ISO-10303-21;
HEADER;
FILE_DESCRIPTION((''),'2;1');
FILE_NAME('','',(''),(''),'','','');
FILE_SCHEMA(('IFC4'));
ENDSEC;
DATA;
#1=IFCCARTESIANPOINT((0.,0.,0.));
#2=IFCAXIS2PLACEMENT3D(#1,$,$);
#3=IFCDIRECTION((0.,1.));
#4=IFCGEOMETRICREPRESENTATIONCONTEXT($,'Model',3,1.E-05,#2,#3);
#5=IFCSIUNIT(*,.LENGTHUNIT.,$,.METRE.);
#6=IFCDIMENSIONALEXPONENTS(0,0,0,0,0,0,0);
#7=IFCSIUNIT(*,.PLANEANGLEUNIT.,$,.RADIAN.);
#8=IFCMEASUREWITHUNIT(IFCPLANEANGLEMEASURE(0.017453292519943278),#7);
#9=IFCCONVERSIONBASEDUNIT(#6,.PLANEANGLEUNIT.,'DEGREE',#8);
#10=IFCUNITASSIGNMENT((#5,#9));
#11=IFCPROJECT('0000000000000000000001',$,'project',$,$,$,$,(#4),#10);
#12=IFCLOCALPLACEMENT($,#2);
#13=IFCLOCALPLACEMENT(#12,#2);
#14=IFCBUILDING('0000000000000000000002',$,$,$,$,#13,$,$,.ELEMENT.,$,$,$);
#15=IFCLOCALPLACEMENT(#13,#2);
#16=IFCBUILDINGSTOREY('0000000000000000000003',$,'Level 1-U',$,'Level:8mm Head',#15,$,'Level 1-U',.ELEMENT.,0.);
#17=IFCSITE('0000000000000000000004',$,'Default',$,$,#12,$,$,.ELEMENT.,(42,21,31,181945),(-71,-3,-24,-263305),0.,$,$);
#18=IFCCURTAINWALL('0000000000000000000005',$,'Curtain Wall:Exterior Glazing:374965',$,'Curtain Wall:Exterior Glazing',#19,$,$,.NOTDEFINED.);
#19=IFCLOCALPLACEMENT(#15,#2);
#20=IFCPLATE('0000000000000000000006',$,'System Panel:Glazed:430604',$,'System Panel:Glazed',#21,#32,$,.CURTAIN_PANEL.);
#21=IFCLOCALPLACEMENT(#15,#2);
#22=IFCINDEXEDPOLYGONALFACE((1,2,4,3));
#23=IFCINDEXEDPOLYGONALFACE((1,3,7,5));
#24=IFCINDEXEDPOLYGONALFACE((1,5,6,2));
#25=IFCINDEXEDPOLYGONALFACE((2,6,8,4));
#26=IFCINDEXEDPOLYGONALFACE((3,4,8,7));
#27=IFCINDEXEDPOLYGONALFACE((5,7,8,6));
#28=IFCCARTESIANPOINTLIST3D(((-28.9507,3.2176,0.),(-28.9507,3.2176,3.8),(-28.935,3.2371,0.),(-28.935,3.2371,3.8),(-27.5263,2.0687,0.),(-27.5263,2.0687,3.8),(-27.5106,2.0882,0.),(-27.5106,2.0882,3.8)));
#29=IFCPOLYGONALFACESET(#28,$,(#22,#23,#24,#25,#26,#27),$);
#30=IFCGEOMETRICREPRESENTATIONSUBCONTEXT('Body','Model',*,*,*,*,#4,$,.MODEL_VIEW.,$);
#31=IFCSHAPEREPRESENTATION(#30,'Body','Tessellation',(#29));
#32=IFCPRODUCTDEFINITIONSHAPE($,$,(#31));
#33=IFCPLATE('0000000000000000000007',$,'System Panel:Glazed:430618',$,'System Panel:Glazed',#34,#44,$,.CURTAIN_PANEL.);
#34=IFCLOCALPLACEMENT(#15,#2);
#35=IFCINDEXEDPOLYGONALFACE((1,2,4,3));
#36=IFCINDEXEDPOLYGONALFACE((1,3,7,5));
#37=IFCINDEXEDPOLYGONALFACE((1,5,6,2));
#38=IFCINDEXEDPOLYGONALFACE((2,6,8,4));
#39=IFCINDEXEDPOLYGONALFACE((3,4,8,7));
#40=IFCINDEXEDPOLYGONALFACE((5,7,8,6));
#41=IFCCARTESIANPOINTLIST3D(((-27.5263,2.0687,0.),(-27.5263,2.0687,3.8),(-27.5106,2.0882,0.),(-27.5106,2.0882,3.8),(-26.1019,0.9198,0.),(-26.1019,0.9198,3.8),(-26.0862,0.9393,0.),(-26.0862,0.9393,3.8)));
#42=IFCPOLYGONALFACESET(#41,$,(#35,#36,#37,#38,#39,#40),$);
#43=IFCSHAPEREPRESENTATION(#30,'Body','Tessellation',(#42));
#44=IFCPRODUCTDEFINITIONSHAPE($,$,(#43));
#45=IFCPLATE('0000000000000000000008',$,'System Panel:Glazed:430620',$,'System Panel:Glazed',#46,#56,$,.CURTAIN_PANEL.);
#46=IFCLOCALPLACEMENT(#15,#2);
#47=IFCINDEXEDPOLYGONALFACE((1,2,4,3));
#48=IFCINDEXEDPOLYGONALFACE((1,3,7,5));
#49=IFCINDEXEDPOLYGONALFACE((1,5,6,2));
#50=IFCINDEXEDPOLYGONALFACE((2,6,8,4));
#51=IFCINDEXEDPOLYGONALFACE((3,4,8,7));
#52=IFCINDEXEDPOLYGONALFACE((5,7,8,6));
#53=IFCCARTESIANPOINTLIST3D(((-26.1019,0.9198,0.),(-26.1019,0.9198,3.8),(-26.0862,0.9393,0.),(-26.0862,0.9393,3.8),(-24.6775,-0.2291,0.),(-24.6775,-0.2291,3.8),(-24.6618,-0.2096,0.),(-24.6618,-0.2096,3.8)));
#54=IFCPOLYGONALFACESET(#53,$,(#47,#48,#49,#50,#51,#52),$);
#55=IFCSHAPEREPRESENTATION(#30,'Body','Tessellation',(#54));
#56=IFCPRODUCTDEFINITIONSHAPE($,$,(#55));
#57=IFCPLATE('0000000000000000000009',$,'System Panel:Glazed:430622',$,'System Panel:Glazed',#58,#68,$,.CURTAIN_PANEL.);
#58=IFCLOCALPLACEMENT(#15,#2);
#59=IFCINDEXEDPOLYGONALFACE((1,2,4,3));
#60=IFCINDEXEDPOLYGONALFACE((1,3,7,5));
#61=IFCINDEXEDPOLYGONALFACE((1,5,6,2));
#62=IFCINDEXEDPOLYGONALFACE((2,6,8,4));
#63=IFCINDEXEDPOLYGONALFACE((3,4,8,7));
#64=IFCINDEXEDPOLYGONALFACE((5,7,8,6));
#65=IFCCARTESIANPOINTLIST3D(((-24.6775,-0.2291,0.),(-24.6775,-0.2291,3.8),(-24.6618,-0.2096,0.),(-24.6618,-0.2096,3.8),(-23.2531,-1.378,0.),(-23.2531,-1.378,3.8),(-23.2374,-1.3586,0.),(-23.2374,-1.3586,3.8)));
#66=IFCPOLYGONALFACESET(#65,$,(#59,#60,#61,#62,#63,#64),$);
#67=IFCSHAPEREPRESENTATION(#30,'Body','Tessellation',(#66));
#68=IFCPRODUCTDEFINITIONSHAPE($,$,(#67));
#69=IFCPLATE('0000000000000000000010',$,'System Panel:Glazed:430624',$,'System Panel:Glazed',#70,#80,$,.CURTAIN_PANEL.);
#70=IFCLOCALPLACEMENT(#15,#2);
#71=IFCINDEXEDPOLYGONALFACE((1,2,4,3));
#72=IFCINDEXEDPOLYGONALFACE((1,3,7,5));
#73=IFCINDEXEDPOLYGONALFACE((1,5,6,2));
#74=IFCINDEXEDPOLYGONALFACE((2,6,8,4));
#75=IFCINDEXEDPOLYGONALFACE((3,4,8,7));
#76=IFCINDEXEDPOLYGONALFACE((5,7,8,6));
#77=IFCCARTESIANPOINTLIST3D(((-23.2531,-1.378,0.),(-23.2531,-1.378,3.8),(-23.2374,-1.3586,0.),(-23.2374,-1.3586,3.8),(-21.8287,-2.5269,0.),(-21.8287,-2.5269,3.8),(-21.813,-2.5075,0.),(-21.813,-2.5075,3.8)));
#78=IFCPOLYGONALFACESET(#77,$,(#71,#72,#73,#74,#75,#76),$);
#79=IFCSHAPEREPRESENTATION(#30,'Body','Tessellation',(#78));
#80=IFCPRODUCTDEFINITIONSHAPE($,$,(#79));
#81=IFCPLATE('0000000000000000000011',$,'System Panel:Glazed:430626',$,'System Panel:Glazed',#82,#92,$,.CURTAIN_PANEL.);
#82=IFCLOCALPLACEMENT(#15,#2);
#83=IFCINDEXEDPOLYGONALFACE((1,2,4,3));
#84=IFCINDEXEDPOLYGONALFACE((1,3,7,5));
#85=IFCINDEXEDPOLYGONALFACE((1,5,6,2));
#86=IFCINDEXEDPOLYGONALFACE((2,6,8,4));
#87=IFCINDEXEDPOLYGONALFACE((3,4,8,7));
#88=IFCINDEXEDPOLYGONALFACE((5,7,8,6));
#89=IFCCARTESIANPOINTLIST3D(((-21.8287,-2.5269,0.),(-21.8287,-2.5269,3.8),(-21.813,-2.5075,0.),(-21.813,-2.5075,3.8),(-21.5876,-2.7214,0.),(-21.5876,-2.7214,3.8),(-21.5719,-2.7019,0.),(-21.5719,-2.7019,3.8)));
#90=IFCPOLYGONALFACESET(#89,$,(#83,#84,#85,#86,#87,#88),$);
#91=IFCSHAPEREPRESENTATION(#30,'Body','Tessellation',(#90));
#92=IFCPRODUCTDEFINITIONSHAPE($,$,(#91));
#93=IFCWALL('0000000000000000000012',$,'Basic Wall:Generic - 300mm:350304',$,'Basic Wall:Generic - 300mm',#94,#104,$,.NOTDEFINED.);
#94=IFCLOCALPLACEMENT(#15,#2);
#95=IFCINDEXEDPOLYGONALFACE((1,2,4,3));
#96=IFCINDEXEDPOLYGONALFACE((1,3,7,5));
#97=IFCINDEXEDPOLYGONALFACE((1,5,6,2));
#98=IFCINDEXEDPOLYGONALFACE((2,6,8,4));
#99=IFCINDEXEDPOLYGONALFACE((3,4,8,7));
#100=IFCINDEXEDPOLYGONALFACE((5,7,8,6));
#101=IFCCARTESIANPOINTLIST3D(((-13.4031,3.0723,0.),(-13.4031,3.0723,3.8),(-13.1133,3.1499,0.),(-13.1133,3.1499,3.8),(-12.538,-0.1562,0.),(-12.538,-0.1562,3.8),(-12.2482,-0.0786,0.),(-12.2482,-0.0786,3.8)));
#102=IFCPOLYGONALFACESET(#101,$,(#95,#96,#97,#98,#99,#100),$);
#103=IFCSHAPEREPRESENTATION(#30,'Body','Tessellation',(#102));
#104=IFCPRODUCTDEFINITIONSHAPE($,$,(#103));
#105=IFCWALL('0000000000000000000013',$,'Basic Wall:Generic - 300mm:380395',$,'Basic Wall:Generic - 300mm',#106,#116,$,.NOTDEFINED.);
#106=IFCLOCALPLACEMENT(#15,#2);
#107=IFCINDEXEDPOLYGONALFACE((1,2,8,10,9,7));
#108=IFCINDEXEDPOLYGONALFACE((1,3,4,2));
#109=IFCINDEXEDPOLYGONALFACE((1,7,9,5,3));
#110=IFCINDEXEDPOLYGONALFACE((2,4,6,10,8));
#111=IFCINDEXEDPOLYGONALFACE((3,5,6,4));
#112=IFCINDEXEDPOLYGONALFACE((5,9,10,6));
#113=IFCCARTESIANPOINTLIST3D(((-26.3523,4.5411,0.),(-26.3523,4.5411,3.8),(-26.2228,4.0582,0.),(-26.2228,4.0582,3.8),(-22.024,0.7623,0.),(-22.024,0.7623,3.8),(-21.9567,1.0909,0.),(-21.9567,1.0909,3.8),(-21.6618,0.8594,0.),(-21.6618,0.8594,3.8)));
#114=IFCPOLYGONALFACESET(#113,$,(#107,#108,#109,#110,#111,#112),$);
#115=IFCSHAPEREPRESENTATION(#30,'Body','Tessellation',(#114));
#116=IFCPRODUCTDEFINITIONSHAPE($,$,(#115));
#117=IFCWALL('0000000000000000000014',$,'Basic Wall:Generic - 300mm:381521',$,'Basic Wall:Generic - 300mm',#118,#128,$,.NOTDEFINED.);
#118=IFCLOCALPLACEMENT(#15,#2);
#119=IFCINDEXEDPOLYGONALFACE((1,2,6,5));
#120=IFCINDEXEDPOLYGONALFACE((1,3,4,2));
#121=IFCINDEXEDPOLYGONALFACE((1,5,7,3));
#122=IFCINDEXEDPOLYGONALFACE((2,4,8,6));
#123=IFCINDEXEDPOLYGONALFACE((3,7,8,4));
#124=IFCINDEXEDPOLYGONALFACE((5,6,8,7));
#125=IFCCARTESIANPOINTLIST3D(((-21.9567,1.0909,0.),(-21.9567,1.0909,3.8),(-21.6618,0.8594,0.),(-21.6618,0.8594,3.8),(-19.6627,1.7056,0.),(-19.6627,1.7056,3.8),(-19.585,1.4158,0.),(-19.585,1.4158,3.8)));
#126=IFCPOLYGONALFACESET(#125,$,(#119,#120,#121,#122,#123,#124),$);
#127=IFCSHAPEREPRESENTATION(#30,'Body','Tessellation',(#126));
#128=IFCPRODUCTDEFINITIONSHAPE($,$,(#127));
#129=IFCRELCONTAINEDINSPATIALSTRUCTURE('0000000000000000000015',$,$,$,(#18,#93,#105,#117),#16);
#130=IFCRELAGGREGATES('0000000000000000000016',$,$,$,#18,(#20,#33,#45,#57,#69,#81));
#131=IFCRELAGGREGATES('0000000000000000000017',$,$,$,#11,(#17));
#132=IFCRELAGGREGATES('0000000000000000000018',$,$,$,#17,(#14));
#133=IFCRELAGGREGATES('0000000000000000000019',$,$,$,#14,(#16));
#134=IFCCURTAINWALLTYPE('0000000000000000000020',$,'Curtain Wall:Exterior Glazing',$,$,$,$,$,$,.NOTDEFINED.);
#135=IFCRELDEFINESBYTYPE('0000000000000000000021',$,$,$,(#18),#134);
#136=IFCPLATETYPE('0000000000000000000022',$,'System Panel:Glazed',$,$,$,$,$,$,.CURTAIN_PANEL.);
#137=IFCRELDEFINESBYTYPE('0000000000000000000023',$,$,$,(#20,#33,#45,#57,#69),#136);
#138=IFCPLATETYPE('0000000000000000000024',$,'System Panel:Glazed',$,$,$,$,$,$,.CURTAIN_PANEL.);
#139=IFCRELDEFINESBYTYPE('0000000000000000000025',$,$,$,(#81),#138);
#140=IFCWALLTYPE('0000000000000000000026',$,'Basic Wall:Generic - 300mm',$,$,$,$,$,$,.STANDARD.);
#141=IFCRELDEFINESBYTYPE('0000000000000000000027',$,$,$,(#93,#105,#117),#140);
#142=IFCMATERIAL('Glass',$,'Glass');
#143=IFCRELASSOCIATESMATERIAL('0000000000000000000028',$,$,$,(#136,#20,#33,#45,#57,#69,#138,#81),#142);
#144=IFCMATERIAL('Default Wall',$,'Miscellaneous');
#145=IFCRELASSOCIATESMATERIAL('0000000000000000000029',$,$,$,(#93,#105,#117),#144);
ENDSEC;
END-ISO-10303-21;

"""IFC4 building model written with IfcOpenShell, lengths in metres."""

from ifc_helpers import new_model, entity, si_unit, converted_unit, direction, frame, origin, place, context, subcontext, project, spatial, indexed_curve, outline, extrude, source, transform, mapped, material, type_object, type_shapes, element, aggregate, save


model = new_model("IFC4")

# Units and contexts
model_context = context("Model", 3, precision=1e-05, world=origin(), true_north=direction((0.0, 1.0)))
body_context = subcontext(model_context, "Body", "Model", "MODEL_VIEW")
ifc_project = project(units=[si_unit("LENGTHUNIT", "METRE"), converted_unit("PLANEANGLEUNIT", "DEGREE", entity("IfcPlaneAngleMeasure", 0.017453292519943278), si_unit("PLANEANGLEUNIT", "RADIAN"), dimensions=[0, 0, 0, 0, 0, 0, 0])], contexts=[model_context])

# Site, building, storey
site_placement = place(None, origin())
site = spatial("IfcSite", under=ifc_project, at=site_placement, Name="Default", CompositionType="ELEMENT", RefLatitude=(42, 21, 31, 181945), RefLongitude=(-71, -3, -24, -263305), RefElevation=0.0)
building_placement = place(site_placement, origin())
building = spatial("IfcBuilding", under=site, at=building_placement, CompositionType="ELEMENT")
storey_placement = place(building_placement, origin())
storey = spatial("IfcBuildingStorey", under=building, at=storey_placement, Name="Level 1-U", ObjectType="Level:8mm Head", LongName="Level 1-U", CompositionType="ELEMENT", Elevation=0.0)

# Curtain wall, plates
curtain_wall_type = type_object("IfcCurtainWallType", Name="Curtain Wall:Exterior Glazing", PredefinedType="NOTDEFINED")
curtain_wall_placement = place(storey_placement, origin())
curtain_wall = element("IfcCurtainWall", 1, at=curtain_wall_placement, inside=storey, type_object=curtain_wall_type, Name="Curtain Wall:Exterior Glazing:374965", ObjectType="Curtain Wall:Exterior Glazing", PredefinedType="NOTDEFINED")
ifc_material_1 = material(Name="Glass", Category="Glass")
plate_type_1 = type_object("IfcPlateType", Name="System Panel:Glazed", PredefinedType="CURTAIN_PANEL", material=ifc_material_1)
shared_shape_1 = source(origin(), body_context, "Body", "SweptSolid", [
    extrude(outline(indexed_curve([(-0.0125, -0.915), (0.0125, -0.915), (0.0125, 0.915), (-0.0125, 0.915), (-0.0125, -0.915)], self_intersect=False)), frame((0.0, 0.037, 0.0), z_axis=(0.0, 0.0, 1.0), x_axis=(0.0, 1.0, 0.0)), (0.0, 0.0, 1.0), 3.8),
])
type_shapes(plate_type_1, [shared_shape_1])
plate_1_placement = place(curtain_wall_placement, frame((-28.2539, 2.6241, 0.0), z_axis=(0.0, 0.0, 1.0), x_axis=(0.778359, -0.62782, 0.0)))
plate_1 = element("IfcPlate", 2, at=plate_1_placement, type_object=plate_type_1, material=ifc_material_1, Name="System Panel:Glazed:430604", ObjectType="System Panel:Glazed", PredefinedType="CURTAIN_PANEL", context=body_context, shape_type="MappedRepresentation", body=[
    mapped(shared_shape_1, transform((0.0, 0.0, 0.0), scale=1.0)),
])
plate_2_placement = place(curtain_wall_placement, frame((-26.8295, 1.4752, 0.0), z_axis=(0.0, 0.0, 1.0), x_axis=(0.778359, -0.62782, 0.0)))
plate_2 = element("IfcPlate", 3, at=plate_2_placement, type_object=plate_type_1, material=ifc_material_1, Name="System Panel:Glazed:430618", ObjectType="System Panel:Glazed", PredefinedType="CURTAIN_PANEL", context=body_context, shape_type="MappedRepresentation", body=[
    mapped(shared_shape_1, transform((0.0, 0.0, 0.0), scale=1.0)),
])
plate_3_placement = place(curtain_wall_placement, frame((-25.4051, 0.3263, 0.0), z_axis=(0.0, 0.0, 1.0), x_axis=(0.778359, -0.62782, 0.0)))
plate_3 = element("IfcPlate", 4, at=plate_3_placement, type_object=plate_type_1, material=ifc_material_1, Name="System Panel:Glazed:430620", ObjectType="System Panel:Glazed", PredefinedType="CURTAIN_PANEL", context=body_context, shape_type="MappedRepresentation", body=[
    mapped(shared_shape_1, transform((0.0, 0.0, 0.0), scale=1.0)),
])
plate_4_placement = place(curtain_wall_placement, frame((-23.9807, -0.8226, 0.0), z_axis=(0.0, 0.0, 1.0), x_axis=(0.778359, -0.62782, 0.0)))
plate_4 = element("IfcPlate", 5, at=plate_4_placement, type_object=plate_type_1, material=ifc_material_1, Name="System Panel:Glazed:430622", ObjectType="System Panel:Glazed", PredefinedType="CURTAIN_PANEL", context=body_context, shape_type="MappedRepresentation", body=[
    mapped(shared_shape_1, transform((0.0, 0.0, 0.0), scale=1.0)),
])
plate_5_placement = place(curtain_wall_placement, frame((-22.5563, -1.9715, 0.0), z_axis=(0.0, 0.0, 1.0), x_axis=(0.778359, -0.62782, 0.0)))
plate_5 = element("IfcPlate", 6, at=plate_5_placement, type_object=plate_type_1, material=ifc_material_1, Name="System Panel:Glazed:430624", ObjectType="System Panel:Glazed", PredefinedType="CURTAIN_PANEL", context=body_context, shape_type="MappedRepresentation", body=[
    mapped(shared_shape_1, transform((0.0, 0.0, 0.0), scale=1.0)),
])
plate_type_2 = type_object("IfcPlateType", Name="System Panel:Glazed", PredefinedType="CURTAIN_PANEL", material=ifc_material_1)
shared_shape_2 = source(origin(), body_context, "Body", "SweptSolid", [
    extrude(outline(indexed_curve([(-0.0125, -0.1549), (0.0125, -0.1549), (0.0125, 0.1549), (-0.0125, 0.1549), (-0.0125, -0.1549)], self_intersect=False)), frame((0.0, 0.037, 0.0), z_axis=(0.0, 0.0, 1.0), x_axis=(0.0, 1.0, 0.0)), (0.0, 0.0, 1.0), 3.8),
])
type_shapes(plate_type_2, [shared_shape_2])
plate_6_placement = place(curtain_wall_placement, frame((-21.7235, -2.6432, 0.0), z_axis=(0.0, 0.0, 1.0), x_axis=(0.778359, -0.62782, 0.0)))
plate_6 = element("IfcPlate", 7, at=plate_6_placement, type_object=plate_type_2, material=ifc_material_1, Name="System Panel:Glazed:430626", ObjectType="System Panel:Glazed", PredefinedType="CURTAIN_PANEL", context=body_context, shape_type="MappedRepresentation", body=[
    mapped(shared_shape_2, transform((0.0, 0.0, 0.0), scale=1.0)),
])
aggregate(curtain_wall, [plate_1, plate_2, plate_3, plate_4, plate_5, plate_6])

# Walls
ifc_material_2 = material(Name="Default Wall", Category="Miscellaneous")
wall_type_1 = type_object("IfcWallType", Name="Basic Wall:Generic - 300mm", PredefinedType="STANDARD")
wall_1_placement = place(storey_placement, frame((-13.2582, 3.1111, 0.0), z_axis=(0.0, 0.0, 1.0), x_axis=(0.258819, -0.965926, 0.0)))
element("IfcWall", 8, at=wall_1_placement, inside=storey, type_object=wall_type_1, material=ifc_material_2, Name="Basic Wall:Generic - 300mm:350304", ObjectType="Basic Wall:Generic - 300mm", PredefinedType="NOTDEFINED", context=body_context, shape_type="SweptSolid", body=[
    extrude(outline(indexed_curve([(3.3424, 0.15), (0.0, 0.15), (0.0, -0.15), (3.3424, -0.15), (3.3424, 0.15)], self_intersect=False)), origin(), (0.0, 0.0, 1.0), 3.8),
])
wall_2_placement = place(storey_placement, frame((-26.4449, 4.4232, 0.0), z_axis=(0.0, 0.0, 1.0), x_axis=(0.786611, -0.617449, 0.0)))
element("IfcWall", 9, at=wall_2_placement, inside=storey, type_object=wall_type_1, material=ifc_material_2, Name="Basic Wall:Generic - 300mm:380395", ObjectType="Basic Wall:Generic - 300mm", PredefinedType="NOTDEFINED", context=body_context, shape_type="SweptSolid", body=[
    extrude(outline(indexed_curve([(5.7379, -0.15), (5.9629, 0.15), (5.5879, 0.15), (0.0, 0.15), (0.4, -0.15), (5.7379, -0.15)], self_intersect=False)), origin(), (0.0, 0.0, 1.0), 3.8),
])
wall_3_placement = place(storey_placement, frame((-19.6238, 1.5607, 0.0), z_axis=(0.0, 0.0, 1.0), x_axis=(-0.965926, -0.258819, 0.0)))
element("IfcWall", 10, at=wall_3_placement, inside=storey, type_object=wall_type_1, material=ifc_material_2, Name="Basic Wall:Generic - 300mm:381521", ObjectType="Basic Wall:Generic - 300mm", PredefinedType="NOTDEFINED", context=body_context, shape_type="SweptSolid", body=[
    extrude(outline(indexed_curve([(2.375, -0.15), (2.15, 0.15), (0.0, 0.15), (0.0, -0.15), (2.375, -0.15)], self_intersect=False)), origin(), (0.0, 0.0, 1.0), 3.8),
])

save(model, "model.ifc")
